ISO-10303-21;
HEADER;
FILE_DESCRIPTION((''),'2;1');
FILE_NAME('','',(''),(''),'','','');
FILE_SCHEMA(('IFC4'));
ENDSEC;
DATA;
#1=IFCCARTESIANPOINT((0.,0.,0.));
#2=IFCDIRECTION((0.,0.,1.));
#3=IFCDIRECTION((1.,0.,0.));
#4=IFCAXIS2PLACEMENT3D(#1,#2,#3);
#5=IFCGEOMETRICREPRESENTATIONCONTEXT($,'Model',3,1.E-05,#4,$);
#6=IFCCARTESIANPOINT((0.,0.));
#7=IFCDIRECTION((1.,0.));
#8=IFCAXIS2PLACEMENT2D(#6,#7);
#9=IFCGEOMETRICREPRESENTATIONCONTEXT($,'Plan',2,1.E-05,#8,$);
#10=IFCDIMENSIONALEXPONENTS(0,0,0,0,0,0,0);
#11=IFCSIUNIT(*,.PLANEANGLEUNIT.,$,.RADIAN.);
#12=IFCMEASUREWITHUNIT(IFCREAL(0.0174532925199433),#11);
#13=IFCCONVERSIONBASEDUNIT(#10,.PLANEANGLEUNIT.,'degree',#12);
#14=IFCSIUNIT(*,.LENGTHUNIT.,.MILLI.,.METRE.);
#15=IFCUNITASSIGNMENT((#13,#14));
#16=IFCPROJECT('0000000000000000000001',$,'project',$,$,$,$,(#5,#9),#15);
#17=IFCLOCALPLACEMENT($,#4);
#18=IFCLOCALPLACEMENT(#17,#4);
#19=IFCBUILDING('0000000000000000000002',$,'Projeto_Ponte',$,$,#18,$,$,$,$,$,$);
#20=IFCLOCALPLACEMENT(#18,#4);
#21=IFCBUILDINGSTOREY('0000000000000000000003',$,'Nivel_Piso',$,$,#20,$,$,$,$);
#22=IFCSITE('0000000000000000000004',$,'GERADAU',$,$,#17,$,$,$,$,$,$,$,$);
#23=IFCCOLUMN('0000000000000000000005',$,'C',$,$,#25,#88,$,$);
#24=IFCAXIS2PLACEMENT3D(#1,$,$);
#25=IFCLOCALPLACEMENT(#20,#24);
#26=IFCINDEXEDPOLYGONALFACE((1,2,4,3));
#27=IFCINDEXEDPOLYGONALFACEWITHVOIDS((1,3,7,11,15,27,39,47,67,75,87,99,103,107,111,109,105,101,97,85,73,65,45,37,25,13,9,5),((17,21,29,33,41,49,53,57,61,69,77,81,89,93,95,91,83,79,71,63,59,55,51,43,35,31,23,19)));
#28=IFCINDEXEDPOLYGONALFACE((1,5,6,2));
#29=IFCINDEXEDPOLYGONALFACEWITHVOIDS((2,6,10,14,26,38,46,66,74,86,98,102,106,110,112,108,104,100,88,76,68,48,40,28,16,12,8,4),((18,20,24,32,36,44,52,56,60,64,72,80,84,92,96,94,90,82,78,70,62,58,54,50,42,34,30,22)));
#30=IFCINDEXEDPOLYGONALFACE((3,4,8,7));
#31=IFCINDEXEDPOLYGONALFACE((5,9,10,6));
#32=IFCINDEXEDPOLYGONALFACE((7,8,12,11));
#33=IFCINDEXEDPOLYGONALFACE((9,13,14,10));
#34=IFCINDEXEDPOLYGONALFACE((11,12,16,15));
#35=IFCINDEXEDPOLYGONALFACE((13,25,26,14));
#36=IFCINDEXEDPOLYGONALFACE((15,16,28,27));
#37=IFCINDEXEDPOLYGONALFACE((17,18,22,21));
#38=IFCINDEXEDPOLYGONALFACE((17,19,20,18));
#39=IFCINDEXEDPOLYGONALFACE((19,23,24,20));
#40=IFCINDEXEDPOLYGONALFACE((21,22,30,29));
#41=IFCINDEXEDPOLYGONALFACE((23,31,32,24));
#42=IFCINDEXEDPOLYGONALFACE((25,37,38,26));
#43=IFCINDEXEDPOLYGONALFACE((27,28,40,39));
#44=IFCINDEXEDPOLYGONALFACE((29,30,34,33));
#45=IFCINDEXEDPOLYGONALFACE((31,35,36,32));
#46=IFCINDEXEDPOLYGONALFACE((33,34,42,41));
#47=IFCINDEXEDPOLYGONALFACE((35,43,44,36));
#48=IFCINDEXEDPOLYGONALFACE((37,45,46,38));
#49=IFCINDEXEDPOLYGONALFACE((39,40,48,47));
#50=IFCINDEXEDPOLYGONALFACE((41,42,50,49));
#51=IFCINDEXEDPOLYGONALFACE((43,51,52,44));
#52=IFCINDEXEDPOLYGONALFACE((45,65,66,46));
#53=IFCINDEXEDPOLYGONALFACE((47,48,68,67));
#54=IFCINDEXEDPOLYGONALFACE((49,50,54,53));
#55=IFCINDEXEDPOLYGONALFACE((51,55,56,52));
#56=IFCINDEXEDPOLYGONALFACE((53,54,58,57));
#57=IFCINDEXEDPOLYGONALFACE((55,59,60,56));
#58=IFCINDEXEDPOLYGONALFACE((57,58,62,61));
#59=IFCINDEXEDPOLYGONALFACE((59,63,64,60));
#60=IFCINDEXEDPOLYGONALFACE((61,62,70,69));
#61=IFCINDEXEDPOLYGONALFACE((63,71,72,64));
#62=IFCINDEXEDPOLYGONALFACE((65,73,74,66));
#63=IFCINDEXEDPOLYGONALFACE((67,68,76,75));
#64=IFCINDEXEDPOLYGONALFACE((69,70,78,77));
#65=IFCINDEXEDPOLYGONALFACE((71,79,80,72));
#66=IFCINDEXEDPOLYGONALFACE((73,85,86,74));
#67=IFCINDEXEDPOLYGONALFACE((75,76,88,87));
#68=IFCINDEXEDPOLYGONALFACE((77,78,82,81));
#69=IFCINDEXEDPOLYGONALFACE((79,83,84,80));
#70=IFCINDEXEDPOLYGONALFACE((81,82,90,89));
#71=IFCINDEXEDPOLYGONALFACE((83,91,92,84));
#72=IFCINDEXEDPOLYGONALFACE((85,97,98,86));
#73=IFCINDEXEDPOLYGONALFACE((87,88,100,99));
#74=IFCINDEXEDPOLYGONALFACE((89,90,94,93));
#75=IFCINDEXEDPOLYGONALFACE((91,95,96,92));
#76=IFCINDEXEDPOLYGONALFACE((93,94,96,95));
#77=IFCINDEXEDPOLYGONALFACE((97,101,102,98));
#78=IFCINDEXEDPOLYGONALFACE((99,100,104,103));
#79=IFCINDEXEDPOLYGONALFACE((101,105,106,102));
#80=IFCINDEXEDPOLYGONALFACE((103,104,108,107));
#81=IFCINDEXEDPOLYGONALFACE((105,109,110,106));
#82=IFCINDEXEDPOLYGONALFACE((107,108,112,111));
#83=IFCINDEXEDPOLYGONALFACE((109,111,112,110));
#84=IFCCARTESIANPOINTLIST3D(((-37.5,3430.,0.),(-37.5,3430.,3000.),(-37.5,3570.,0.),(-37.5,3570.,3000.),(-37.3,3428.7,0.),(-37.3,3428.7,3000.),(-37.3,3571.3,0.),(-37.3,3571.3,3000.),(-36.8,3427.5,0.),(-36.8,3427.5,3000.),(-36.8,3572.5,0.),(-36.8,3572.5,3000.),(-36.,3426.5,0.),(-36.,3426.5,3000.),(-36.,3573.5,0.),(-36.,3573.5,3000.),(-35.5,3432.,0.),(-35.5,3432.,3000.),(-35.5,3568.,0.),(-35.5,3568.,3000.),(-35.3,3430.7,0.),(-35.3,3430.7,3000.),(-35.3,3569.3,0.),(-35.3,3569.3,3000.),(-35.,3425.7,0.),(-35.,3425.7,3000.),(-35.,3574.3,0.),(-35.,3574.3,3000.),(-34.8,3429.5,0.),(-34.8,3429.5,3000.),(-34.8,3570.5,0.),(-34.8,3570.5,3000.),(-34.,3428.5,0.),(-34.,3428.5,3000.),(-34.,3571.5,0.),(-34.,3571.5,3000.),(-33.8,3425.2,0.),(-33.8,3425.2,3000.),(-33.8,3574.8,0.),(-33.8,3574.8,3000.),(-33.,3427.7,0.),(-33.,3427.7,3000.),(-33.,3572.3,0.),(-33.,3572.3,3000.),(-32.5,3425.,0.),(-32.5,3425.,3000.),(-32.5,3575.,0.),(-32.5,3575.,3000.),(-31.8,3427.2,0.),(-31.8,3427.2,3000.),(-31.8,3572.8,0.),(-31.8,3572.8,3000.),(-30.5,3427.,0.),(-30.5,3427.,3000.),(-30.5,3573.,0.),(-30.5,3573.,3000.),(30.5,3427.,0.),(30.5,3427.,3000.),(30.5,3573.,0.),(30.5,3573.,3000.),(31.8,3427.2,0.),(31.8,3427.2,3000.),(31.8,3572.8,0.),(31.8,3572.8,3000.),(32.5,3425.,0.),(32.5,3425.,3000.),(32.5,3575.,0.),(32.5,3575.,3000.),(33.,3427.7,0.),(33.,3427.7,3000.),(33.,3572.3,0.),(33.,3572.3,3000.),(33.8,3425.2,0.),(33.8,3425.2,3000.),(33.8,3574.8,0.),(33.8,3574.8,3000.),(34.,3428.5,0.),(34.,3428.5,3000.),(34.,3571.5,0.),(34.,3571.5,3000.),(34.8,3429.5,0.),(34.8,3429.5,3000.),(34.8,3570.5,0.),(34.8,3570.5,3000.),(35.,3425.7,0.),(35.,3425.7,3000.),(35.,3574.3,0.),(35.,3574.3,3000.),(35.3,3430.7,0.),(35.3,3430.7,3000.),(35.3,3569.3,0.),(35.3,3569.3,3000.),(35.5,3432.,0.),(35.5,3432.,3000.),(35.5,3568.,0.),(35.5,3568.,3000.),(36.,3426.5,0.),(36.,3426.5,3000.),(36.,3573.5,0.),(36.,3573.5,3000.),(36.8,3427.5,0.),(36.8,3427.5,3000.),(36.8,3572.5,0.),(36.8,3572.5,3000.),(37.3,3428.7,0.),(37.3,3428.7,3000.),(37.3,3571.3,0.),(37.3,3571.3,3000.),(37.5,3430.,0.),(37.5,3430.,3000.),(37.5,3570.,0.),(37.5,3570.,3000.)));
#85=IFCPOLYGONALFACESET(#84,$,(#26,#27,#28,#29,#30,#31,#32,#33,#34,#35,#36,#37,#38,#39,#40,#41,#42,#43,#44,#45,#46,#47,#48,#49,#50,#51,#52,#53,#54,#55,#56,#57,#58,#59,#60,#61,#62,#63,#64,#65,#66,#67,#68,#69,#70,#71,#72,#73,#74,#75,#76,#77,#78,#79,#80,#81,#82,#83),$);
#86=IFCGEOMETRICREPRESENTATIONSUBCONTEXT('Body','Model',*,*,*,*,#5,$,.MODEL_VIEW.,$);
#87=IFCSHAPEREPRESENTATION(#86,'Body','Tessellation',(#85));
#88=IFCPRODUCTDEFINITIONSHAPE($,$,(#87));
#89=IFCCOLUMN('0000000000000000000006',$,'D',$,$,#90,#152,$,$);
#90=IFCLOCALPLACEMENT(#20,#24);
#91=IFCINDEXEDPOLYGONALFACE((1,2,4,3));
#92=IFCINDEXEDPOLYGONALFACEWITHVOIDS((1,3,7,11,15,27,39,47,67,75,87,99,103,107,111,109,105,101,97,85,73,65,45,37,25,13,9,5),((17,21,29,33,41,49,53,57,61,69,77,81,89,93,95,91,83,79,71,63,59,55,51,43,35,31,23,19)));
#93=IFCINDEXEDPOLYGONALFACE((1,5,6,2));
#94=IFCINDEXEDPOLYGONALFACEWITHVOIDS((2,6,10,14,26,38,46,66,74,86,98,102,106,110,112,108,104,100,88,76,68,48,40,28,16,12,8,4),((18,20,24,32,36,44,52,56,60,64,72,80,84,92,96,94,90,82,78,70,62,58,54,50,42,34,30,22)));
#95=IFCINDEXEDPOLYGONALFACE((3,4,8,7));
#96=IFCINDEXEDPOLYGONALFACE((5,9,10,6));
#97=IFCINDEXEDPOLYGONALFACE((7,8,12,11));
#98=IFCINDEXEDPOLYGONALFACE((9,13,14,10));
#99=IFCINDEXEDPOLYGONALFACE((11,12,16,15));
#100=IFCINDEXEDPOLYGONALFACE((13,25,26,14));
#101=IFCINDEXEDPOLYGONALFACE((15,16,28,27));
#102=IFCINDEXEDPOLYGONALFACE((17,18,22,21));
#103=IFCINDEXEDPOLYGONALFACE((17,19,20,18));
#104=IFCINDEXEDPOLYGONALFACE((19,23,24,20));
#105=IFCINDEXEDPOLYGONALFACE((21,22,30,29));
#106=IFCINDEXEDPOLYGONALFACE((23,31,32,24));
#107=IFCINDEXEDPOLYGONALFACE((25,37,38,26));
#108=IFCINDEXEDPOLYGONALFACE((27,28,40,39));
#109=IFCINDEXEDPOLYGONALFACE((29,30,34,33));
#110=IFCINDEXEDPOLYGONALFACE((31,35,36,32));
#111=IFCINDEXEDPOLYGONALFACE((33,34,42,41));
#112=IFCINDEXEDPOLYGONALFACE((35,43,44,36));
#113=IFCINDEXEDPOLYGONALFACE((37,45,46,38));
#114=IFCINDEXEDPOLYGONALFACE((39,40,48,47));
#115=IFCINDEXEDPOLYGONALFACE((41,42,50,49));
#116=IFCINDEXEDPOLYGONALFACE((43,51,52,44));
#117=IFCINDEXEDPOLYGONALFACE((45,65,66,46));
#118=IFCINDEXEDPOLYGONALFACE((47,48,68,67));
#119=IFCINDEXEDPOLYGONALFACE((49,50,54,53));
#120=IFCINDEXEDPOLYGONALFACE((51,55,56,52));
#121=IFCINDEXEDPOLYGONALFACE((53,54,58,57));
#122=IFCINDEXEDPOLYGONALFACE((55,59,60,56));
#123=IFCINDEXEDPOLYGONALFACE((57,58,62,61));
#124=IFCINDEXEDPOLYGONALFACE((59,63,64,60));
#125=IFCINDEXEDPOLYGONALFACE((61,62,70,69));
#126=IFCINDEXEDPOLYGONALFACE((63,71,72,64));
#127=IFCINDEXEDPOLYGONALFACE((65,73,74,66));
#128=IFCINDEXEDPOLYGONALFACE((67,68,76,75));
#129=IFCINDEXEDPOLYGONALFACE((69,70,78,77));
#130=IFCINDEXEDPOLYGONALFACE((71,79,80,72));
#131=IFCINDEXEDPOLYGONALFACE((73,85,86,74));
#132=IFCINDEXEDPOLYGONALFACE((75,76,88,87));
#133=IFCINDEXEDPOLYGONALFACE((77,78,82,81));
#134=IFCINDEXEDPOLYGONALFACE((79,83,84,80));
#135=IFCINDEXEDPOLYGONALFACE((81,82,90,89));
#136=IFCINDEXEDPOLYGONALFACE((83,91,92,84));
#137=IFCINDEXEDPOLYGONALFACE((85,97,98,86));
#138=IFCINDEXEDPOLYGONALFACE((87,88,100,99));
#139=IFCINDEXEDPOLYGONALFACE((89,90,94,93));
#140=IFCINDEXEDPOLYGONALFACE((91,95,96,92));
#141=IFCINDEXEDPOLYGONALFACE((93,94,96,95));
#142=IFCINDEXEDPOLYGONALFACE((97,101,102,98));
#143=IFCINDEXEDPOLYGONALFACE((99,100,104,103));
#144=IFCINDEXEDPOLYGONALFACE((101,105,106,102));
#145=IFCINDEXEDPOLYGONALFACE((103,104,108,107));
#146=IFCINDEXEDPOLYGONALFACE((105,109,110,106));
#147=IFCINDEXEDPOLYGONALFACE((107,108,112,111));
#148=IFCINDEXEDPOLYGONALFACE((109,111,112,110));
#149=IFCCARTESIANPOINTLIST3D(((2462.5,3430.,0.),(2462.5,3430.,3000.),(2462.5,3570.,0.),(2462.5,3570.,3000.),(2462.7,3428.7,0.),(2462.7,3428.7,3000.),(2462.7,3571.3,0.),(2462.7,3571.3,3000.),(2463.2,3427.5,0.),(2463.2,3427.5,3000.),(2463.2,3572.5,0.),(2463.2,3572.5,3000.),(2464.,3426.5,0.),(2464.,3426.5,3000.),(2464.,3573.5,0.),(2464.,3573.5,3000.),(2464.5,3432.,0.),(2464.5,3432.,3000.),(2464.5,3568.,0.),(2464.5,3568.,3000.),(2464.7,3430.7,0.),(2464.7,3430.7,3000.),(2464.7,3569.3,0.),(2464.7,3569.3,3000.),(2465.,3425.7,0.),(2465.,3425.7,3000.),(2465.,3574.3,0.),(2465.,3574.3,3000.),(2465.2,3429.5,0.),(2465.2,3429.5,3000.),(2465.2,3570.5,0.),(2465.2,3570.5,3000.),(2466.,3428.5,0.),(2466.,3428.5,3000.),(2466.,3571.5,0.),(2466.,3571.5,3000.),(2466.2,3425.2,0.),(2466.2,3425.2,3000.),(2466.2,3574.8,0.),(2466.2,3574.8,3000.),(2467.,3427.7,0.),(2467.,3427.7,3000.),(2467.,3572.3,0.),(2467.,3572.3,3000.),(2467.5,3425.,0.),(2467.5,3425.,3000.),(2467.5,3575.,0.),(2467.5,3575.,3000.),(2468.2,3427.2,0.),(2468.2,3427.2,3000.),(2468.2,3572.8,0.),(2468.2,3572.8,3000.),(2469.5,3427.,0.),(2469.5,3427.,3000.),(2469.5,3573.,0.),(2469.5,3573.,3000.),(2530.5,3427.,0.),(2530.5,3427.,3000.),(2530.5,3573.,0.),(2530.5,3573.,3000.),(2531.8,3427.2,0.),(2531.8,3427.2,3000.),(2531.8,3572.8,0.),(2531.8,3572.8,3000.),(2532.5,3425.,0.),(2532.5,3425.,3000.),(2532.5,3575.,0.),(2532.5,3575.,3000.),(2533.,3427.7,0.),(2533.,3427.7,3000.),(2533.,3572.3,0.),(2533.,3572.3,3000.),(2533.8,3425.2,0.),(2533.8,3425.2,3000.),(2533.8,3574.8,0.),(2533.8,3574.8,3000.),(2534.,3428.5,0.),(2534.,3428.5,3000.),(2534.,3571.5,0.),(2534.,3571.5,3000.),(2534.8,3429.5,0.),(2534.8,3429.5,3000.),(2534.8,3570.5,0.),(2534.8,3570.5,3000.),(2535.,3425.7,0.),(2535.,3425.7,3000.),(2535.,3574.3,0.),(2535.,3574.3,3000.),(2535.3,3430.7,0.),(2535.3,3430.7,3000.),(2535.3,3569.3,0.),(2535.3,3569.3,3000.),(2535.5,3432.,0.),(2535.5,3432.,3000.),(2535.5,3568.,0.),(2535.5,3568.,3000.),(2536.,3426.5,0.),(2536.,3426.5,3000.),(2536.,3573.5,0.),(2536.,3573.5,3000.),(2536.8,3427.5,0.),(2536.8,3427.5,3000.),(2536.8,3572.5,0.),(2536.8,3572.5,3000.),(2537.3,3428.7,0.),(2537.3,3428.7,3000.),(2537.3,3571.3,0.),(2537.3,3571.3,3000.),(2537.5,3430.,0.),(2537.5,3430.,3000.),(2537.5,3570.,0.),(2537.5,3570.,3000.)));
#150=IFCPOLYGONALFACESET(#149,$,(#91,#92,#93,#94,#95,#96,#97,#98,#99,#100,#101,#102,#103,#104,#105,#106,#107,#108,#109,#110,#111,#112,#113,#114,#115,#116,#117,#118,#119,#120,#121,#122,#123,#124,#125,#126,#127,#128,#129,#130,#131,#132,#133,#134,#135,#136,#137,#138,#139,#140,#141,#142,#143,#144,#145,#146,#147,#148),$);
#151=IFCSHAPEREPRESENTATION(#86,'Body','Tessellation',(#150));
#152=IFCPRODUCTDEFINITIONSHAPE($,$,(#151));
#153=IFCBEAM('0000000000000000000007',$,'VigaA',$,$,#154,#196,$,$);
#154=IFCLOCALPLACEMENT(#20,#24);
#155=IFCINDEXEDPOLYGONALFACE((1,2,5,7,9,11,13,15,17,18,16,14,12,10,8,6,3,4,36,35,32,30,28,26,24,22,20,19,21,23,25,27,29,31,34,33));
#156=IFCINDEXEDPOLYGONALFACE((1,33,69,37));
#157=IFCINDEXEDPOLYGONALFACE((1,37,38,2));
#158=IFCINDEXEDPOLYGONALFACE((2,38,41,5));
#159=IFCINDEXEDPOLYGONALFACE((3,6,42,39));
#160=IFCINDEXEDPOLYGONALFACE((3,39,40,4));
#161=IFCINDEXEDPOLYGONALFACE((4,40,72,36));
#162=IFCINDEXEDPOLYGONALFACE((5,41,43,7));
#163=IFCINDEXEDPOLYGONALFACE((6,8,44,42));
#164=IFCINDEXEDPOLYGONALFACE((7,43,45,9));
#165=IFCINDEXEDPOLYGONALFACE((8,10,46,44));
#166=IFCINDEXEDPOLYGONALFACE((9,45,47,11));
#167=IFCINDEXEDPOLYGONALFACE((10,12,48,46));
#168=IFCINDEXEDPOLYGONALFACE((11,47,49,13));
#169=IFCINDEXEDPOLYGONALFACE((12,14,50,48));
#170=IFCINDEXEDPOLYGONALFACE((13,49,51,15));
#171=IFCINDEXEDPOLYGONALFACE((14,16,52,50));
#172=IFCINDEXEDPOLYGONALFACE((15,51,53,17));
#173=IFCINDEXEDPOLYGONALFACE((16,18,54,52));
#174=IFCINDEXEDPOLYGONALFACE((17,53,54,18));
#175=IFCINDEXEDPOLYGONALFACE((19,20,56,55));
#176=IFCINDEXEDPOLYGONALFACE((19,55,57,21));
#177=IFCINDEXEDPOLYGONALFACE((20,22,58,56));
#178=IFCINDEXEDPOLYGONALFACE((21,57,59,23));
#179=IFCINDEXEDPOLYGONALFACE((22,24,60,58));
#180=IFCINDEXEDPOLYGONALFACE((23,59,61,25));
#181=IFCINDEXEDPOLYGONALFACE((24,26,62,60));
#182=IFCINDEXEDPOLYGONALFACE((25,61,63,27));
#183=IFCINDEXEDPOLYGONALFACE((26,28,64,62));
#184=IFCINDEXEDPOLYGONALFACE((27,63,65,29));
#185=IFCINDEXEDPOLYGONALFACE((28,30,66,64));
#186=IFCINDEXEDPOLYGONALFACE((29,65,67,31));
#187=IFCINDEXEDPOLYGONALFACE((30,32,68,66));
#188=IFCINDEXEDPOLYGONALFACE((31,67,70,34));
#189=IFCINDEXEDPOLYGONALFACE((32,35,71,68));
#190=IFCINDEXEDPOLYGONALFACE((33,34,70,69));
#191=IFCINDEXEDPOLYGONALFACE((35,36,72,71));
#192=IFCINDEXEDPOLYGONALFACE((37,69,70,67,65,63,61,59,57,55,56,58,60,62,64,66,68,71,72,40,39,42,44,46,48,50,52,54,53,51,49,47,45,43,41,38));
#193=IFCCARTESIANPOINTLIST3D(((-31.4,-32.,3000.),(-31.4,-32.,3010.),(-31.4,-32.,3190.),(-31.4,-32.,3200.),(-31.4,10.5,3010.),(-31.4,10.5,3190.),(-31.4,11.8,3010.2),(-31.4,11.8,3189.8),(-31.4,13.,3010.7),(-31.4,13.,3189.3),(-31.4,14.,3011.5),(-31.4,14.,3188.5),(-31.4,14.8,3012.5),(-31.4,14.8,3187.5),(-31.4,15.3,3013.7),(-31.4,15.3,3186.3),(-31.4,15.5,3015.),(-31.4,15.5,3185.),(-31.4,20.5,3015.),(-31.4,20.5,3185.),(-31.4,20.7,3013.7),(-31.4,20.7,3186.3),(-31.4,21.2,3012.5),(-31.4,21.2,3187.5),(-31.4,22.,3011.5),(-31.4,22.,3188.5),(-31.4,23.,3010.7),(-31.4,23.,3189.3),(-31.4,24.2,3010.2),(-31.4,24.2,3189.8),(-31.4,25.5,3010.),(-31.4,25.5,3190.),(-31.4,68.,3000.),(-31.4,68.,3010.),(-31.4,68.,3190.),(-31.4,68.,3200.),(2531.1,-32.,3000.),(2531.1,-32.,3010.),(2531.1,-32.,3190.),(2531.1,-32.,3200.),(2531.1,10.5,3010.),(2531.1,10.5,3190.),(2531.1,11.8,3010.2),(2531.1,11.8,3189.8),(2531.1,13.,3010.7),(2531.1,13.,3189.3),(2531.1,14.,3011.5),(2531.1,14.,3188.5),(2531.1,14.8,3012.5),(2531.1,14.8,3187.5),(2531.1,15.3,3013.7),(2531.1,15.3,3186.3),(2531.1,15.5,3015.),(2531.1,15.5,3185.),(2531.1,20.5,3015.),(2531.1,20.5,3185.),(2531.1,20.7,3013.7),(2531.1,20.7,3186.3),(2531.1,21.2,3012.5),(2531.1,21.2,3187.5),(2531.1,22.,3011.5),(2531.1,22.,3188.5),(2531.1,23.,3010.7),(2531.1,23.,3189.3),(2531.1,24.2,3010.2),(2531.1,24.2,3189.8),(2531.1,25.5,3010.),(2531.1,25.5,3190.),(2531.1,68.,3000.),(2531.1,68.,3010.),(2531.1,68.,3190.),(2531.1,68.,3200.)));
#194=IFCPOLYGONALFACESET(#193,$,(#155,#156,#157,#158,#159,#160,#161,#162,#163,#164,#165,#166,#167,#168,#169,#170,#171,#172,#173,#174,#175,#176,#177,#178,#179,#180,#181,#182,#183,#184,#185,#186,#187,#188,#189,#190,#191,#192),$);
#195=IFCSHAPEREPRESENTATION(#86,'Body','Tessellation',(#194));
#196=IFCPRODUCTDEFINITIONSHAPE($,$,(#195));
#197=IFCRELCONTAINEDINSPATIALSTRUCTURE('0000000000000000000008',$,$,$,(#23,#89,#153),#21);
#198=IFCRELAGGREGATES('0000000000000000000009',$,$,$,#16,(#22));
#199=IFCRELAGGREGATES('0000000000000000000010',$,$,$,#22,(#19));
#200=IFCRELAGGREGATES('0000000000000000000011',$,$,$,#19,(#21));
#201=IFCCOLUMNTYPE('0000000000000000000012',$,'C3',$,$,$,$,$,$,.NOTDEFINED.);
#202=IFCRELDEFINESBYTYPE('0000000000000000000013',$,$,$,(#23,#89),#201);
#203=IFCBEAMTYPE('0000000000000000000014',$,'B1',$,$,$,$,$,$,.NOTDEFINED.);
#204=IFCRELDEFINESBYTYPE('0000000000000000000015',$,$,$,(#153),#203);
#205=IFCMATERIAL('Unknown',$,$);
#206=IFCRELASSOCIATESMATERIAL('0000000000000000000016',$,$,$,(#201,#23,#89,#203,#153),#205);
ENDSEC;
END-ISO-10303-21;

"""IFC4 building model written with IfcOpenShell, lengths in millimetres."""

from ifc_helpers import new_model, entity, si_unit, converted_unit, frame, origin_with_axes, origin_2d_with_axis, place, context, subcontext, project, spatial, hollow_rectangle, i_section, extrude, material, material_profile, profile_set, profile_usage, type_object, element, save


model = new_model("IFC4")

# Units and contexts
model_context = context("Model", 3, precision=1e-05, world=origin_with_axes())
plan_context = context("Plan", 2, precision=1e-05, world=origin_2d_with_axis())
body_context = subcontext(model_context, "Body", "Model", "MODEL_VIEW")
ifc_project = project(units=[converted_unit("PLANEANGLEUNIT", "degree", entity("IfcReal", 0.0174532925199433), si_unit("PLANEANGLEUNIT", "RADIAN"), dimensions=[0, 0, 0, 0, 0, 0, 0]), si_unit("LENGTHUNIT", "METRE", prefix="MILLI")], contexts=[model_context, plan_context])

# Site, building, storey
site_placement = place(None, origin_with_axes())
site = spatial("IfcSite", under=ifc_project, at=site_placement, Name="GERADAU")
building_placement = place(site_placement, origin_with_axes())
building = spatial("IfcBuilding", under=site, at=building_placement, Name="Projeto_Ponte")
storey_placement = place(building_placement, origin_with_axes())
storey = spatial("IfcBuildingStorey", under=building, at=storey_placement, Name="Nivel_Piso")

# Columns
ifc_material = material(Name="Unknown")
ifc_material_profile_1 = material_profile(ifc_material, hollow_rectangle(XDim=75.0, YDim=150.0, WallThickness=2.0, InnerFilletRadius=5.0, OuterFilletRadius=5.0))
ifc_profile_set_1 = profile_set([ifc_material_profile_1])
column_type = type_object("IfcColumnType", Name="C3", PredefinedType="NOTDEFINED", material=ifc_profile_set_1)
ifc_profile_usage_1 = profile_usage(ifc_profile_set_1, cardinal=5)
column_1_placement = place(storey_placement, frame((0.0, 3500.0, 0.0), z_axis=(0.0, 0.0, 1.0), x_axis=(1.0, 0.0, 0.0)))
element("IfcColumn", 1, at=column_1_placement, inside=storey, type_object=column_type, material=ifc_profile_usage_1, Name="C", context=body_context, shape_type="SweptSolid", body=[
    extrude(hollow_rectangle(XDim=75.0, YDim=150.0, WallThickness=2.0, InnerFilletRadius=5.0, OuterFilletRadius=5.0), origin_with_axes(), (0.0, 0.0, 1.0), 3000.0),
])
ifc_profile_usage_2 = profile_usage(ifc_profile_set_1, cardinal=5)
column_2_placement = place(storey_placement, frame((2500.0, 3500.0, 0.0), z_axis=(0.0, 0.0, 1.0), x_axis=(1.0, 0.0, 0.0)))
element("IfcColumn", 2, at=column_2_placement, inside=storey, type_object=column_type, material=ifc_profile_usage_2, Name="D", context=body_context, shape_type="SweptSolid", body=[
    extrude(hollow_rectangle(XDim=75.0, YDim=150.0, WallThickness=2.0, InnerFilletRadius=5.0, OuterFilletRadius=5.0), origin_with_axes(), (0.0, 0.0, 1.0), 3000.0),
])

# Beam
ifc_material_profile_2 = material_profile(ifc_material, i_section(OverallWidth=100.0, OverallDepth=200.0, WebThickness=5.0, FlangeThickness=10.0, FilletRadius=5.0))
ifc_profile_set_2 = profile_set([ifc_material_profile_2])
ifc_profile_usage_3 = profile_usage(ifc_profile_set_2, cardinal=5)
beam_type_1 = type_object("IfcBeamType", Name="B1", PredefinedType="NOTDEFINED", material=ifc_profile_set_2)
beam_1_placement = place(storey_placement, frame((-31.4, 18.0, 3100.0), z_axis=(1.0, 0.0, 0.0), x_axis=(0.0, 1.0, 0.0)))
element("IfcBeam", 3, at=beam_1_placement, inside=storey, type_object=beam_type_1, material=ifc_profile_usage_3, Name="VigaA", context=body_context, shape_type="SweptSolid", body=[
    extrude(i_section(OverallWidth=100.0, OverallDepth=200.0, WebThickness=5.0, FlangeThickness=10.0, FilletRadius=5.0), origin_with_axes(), (0.0, 0.0, 1.0), 2562.5),
])

save(model, "model.ifc")
